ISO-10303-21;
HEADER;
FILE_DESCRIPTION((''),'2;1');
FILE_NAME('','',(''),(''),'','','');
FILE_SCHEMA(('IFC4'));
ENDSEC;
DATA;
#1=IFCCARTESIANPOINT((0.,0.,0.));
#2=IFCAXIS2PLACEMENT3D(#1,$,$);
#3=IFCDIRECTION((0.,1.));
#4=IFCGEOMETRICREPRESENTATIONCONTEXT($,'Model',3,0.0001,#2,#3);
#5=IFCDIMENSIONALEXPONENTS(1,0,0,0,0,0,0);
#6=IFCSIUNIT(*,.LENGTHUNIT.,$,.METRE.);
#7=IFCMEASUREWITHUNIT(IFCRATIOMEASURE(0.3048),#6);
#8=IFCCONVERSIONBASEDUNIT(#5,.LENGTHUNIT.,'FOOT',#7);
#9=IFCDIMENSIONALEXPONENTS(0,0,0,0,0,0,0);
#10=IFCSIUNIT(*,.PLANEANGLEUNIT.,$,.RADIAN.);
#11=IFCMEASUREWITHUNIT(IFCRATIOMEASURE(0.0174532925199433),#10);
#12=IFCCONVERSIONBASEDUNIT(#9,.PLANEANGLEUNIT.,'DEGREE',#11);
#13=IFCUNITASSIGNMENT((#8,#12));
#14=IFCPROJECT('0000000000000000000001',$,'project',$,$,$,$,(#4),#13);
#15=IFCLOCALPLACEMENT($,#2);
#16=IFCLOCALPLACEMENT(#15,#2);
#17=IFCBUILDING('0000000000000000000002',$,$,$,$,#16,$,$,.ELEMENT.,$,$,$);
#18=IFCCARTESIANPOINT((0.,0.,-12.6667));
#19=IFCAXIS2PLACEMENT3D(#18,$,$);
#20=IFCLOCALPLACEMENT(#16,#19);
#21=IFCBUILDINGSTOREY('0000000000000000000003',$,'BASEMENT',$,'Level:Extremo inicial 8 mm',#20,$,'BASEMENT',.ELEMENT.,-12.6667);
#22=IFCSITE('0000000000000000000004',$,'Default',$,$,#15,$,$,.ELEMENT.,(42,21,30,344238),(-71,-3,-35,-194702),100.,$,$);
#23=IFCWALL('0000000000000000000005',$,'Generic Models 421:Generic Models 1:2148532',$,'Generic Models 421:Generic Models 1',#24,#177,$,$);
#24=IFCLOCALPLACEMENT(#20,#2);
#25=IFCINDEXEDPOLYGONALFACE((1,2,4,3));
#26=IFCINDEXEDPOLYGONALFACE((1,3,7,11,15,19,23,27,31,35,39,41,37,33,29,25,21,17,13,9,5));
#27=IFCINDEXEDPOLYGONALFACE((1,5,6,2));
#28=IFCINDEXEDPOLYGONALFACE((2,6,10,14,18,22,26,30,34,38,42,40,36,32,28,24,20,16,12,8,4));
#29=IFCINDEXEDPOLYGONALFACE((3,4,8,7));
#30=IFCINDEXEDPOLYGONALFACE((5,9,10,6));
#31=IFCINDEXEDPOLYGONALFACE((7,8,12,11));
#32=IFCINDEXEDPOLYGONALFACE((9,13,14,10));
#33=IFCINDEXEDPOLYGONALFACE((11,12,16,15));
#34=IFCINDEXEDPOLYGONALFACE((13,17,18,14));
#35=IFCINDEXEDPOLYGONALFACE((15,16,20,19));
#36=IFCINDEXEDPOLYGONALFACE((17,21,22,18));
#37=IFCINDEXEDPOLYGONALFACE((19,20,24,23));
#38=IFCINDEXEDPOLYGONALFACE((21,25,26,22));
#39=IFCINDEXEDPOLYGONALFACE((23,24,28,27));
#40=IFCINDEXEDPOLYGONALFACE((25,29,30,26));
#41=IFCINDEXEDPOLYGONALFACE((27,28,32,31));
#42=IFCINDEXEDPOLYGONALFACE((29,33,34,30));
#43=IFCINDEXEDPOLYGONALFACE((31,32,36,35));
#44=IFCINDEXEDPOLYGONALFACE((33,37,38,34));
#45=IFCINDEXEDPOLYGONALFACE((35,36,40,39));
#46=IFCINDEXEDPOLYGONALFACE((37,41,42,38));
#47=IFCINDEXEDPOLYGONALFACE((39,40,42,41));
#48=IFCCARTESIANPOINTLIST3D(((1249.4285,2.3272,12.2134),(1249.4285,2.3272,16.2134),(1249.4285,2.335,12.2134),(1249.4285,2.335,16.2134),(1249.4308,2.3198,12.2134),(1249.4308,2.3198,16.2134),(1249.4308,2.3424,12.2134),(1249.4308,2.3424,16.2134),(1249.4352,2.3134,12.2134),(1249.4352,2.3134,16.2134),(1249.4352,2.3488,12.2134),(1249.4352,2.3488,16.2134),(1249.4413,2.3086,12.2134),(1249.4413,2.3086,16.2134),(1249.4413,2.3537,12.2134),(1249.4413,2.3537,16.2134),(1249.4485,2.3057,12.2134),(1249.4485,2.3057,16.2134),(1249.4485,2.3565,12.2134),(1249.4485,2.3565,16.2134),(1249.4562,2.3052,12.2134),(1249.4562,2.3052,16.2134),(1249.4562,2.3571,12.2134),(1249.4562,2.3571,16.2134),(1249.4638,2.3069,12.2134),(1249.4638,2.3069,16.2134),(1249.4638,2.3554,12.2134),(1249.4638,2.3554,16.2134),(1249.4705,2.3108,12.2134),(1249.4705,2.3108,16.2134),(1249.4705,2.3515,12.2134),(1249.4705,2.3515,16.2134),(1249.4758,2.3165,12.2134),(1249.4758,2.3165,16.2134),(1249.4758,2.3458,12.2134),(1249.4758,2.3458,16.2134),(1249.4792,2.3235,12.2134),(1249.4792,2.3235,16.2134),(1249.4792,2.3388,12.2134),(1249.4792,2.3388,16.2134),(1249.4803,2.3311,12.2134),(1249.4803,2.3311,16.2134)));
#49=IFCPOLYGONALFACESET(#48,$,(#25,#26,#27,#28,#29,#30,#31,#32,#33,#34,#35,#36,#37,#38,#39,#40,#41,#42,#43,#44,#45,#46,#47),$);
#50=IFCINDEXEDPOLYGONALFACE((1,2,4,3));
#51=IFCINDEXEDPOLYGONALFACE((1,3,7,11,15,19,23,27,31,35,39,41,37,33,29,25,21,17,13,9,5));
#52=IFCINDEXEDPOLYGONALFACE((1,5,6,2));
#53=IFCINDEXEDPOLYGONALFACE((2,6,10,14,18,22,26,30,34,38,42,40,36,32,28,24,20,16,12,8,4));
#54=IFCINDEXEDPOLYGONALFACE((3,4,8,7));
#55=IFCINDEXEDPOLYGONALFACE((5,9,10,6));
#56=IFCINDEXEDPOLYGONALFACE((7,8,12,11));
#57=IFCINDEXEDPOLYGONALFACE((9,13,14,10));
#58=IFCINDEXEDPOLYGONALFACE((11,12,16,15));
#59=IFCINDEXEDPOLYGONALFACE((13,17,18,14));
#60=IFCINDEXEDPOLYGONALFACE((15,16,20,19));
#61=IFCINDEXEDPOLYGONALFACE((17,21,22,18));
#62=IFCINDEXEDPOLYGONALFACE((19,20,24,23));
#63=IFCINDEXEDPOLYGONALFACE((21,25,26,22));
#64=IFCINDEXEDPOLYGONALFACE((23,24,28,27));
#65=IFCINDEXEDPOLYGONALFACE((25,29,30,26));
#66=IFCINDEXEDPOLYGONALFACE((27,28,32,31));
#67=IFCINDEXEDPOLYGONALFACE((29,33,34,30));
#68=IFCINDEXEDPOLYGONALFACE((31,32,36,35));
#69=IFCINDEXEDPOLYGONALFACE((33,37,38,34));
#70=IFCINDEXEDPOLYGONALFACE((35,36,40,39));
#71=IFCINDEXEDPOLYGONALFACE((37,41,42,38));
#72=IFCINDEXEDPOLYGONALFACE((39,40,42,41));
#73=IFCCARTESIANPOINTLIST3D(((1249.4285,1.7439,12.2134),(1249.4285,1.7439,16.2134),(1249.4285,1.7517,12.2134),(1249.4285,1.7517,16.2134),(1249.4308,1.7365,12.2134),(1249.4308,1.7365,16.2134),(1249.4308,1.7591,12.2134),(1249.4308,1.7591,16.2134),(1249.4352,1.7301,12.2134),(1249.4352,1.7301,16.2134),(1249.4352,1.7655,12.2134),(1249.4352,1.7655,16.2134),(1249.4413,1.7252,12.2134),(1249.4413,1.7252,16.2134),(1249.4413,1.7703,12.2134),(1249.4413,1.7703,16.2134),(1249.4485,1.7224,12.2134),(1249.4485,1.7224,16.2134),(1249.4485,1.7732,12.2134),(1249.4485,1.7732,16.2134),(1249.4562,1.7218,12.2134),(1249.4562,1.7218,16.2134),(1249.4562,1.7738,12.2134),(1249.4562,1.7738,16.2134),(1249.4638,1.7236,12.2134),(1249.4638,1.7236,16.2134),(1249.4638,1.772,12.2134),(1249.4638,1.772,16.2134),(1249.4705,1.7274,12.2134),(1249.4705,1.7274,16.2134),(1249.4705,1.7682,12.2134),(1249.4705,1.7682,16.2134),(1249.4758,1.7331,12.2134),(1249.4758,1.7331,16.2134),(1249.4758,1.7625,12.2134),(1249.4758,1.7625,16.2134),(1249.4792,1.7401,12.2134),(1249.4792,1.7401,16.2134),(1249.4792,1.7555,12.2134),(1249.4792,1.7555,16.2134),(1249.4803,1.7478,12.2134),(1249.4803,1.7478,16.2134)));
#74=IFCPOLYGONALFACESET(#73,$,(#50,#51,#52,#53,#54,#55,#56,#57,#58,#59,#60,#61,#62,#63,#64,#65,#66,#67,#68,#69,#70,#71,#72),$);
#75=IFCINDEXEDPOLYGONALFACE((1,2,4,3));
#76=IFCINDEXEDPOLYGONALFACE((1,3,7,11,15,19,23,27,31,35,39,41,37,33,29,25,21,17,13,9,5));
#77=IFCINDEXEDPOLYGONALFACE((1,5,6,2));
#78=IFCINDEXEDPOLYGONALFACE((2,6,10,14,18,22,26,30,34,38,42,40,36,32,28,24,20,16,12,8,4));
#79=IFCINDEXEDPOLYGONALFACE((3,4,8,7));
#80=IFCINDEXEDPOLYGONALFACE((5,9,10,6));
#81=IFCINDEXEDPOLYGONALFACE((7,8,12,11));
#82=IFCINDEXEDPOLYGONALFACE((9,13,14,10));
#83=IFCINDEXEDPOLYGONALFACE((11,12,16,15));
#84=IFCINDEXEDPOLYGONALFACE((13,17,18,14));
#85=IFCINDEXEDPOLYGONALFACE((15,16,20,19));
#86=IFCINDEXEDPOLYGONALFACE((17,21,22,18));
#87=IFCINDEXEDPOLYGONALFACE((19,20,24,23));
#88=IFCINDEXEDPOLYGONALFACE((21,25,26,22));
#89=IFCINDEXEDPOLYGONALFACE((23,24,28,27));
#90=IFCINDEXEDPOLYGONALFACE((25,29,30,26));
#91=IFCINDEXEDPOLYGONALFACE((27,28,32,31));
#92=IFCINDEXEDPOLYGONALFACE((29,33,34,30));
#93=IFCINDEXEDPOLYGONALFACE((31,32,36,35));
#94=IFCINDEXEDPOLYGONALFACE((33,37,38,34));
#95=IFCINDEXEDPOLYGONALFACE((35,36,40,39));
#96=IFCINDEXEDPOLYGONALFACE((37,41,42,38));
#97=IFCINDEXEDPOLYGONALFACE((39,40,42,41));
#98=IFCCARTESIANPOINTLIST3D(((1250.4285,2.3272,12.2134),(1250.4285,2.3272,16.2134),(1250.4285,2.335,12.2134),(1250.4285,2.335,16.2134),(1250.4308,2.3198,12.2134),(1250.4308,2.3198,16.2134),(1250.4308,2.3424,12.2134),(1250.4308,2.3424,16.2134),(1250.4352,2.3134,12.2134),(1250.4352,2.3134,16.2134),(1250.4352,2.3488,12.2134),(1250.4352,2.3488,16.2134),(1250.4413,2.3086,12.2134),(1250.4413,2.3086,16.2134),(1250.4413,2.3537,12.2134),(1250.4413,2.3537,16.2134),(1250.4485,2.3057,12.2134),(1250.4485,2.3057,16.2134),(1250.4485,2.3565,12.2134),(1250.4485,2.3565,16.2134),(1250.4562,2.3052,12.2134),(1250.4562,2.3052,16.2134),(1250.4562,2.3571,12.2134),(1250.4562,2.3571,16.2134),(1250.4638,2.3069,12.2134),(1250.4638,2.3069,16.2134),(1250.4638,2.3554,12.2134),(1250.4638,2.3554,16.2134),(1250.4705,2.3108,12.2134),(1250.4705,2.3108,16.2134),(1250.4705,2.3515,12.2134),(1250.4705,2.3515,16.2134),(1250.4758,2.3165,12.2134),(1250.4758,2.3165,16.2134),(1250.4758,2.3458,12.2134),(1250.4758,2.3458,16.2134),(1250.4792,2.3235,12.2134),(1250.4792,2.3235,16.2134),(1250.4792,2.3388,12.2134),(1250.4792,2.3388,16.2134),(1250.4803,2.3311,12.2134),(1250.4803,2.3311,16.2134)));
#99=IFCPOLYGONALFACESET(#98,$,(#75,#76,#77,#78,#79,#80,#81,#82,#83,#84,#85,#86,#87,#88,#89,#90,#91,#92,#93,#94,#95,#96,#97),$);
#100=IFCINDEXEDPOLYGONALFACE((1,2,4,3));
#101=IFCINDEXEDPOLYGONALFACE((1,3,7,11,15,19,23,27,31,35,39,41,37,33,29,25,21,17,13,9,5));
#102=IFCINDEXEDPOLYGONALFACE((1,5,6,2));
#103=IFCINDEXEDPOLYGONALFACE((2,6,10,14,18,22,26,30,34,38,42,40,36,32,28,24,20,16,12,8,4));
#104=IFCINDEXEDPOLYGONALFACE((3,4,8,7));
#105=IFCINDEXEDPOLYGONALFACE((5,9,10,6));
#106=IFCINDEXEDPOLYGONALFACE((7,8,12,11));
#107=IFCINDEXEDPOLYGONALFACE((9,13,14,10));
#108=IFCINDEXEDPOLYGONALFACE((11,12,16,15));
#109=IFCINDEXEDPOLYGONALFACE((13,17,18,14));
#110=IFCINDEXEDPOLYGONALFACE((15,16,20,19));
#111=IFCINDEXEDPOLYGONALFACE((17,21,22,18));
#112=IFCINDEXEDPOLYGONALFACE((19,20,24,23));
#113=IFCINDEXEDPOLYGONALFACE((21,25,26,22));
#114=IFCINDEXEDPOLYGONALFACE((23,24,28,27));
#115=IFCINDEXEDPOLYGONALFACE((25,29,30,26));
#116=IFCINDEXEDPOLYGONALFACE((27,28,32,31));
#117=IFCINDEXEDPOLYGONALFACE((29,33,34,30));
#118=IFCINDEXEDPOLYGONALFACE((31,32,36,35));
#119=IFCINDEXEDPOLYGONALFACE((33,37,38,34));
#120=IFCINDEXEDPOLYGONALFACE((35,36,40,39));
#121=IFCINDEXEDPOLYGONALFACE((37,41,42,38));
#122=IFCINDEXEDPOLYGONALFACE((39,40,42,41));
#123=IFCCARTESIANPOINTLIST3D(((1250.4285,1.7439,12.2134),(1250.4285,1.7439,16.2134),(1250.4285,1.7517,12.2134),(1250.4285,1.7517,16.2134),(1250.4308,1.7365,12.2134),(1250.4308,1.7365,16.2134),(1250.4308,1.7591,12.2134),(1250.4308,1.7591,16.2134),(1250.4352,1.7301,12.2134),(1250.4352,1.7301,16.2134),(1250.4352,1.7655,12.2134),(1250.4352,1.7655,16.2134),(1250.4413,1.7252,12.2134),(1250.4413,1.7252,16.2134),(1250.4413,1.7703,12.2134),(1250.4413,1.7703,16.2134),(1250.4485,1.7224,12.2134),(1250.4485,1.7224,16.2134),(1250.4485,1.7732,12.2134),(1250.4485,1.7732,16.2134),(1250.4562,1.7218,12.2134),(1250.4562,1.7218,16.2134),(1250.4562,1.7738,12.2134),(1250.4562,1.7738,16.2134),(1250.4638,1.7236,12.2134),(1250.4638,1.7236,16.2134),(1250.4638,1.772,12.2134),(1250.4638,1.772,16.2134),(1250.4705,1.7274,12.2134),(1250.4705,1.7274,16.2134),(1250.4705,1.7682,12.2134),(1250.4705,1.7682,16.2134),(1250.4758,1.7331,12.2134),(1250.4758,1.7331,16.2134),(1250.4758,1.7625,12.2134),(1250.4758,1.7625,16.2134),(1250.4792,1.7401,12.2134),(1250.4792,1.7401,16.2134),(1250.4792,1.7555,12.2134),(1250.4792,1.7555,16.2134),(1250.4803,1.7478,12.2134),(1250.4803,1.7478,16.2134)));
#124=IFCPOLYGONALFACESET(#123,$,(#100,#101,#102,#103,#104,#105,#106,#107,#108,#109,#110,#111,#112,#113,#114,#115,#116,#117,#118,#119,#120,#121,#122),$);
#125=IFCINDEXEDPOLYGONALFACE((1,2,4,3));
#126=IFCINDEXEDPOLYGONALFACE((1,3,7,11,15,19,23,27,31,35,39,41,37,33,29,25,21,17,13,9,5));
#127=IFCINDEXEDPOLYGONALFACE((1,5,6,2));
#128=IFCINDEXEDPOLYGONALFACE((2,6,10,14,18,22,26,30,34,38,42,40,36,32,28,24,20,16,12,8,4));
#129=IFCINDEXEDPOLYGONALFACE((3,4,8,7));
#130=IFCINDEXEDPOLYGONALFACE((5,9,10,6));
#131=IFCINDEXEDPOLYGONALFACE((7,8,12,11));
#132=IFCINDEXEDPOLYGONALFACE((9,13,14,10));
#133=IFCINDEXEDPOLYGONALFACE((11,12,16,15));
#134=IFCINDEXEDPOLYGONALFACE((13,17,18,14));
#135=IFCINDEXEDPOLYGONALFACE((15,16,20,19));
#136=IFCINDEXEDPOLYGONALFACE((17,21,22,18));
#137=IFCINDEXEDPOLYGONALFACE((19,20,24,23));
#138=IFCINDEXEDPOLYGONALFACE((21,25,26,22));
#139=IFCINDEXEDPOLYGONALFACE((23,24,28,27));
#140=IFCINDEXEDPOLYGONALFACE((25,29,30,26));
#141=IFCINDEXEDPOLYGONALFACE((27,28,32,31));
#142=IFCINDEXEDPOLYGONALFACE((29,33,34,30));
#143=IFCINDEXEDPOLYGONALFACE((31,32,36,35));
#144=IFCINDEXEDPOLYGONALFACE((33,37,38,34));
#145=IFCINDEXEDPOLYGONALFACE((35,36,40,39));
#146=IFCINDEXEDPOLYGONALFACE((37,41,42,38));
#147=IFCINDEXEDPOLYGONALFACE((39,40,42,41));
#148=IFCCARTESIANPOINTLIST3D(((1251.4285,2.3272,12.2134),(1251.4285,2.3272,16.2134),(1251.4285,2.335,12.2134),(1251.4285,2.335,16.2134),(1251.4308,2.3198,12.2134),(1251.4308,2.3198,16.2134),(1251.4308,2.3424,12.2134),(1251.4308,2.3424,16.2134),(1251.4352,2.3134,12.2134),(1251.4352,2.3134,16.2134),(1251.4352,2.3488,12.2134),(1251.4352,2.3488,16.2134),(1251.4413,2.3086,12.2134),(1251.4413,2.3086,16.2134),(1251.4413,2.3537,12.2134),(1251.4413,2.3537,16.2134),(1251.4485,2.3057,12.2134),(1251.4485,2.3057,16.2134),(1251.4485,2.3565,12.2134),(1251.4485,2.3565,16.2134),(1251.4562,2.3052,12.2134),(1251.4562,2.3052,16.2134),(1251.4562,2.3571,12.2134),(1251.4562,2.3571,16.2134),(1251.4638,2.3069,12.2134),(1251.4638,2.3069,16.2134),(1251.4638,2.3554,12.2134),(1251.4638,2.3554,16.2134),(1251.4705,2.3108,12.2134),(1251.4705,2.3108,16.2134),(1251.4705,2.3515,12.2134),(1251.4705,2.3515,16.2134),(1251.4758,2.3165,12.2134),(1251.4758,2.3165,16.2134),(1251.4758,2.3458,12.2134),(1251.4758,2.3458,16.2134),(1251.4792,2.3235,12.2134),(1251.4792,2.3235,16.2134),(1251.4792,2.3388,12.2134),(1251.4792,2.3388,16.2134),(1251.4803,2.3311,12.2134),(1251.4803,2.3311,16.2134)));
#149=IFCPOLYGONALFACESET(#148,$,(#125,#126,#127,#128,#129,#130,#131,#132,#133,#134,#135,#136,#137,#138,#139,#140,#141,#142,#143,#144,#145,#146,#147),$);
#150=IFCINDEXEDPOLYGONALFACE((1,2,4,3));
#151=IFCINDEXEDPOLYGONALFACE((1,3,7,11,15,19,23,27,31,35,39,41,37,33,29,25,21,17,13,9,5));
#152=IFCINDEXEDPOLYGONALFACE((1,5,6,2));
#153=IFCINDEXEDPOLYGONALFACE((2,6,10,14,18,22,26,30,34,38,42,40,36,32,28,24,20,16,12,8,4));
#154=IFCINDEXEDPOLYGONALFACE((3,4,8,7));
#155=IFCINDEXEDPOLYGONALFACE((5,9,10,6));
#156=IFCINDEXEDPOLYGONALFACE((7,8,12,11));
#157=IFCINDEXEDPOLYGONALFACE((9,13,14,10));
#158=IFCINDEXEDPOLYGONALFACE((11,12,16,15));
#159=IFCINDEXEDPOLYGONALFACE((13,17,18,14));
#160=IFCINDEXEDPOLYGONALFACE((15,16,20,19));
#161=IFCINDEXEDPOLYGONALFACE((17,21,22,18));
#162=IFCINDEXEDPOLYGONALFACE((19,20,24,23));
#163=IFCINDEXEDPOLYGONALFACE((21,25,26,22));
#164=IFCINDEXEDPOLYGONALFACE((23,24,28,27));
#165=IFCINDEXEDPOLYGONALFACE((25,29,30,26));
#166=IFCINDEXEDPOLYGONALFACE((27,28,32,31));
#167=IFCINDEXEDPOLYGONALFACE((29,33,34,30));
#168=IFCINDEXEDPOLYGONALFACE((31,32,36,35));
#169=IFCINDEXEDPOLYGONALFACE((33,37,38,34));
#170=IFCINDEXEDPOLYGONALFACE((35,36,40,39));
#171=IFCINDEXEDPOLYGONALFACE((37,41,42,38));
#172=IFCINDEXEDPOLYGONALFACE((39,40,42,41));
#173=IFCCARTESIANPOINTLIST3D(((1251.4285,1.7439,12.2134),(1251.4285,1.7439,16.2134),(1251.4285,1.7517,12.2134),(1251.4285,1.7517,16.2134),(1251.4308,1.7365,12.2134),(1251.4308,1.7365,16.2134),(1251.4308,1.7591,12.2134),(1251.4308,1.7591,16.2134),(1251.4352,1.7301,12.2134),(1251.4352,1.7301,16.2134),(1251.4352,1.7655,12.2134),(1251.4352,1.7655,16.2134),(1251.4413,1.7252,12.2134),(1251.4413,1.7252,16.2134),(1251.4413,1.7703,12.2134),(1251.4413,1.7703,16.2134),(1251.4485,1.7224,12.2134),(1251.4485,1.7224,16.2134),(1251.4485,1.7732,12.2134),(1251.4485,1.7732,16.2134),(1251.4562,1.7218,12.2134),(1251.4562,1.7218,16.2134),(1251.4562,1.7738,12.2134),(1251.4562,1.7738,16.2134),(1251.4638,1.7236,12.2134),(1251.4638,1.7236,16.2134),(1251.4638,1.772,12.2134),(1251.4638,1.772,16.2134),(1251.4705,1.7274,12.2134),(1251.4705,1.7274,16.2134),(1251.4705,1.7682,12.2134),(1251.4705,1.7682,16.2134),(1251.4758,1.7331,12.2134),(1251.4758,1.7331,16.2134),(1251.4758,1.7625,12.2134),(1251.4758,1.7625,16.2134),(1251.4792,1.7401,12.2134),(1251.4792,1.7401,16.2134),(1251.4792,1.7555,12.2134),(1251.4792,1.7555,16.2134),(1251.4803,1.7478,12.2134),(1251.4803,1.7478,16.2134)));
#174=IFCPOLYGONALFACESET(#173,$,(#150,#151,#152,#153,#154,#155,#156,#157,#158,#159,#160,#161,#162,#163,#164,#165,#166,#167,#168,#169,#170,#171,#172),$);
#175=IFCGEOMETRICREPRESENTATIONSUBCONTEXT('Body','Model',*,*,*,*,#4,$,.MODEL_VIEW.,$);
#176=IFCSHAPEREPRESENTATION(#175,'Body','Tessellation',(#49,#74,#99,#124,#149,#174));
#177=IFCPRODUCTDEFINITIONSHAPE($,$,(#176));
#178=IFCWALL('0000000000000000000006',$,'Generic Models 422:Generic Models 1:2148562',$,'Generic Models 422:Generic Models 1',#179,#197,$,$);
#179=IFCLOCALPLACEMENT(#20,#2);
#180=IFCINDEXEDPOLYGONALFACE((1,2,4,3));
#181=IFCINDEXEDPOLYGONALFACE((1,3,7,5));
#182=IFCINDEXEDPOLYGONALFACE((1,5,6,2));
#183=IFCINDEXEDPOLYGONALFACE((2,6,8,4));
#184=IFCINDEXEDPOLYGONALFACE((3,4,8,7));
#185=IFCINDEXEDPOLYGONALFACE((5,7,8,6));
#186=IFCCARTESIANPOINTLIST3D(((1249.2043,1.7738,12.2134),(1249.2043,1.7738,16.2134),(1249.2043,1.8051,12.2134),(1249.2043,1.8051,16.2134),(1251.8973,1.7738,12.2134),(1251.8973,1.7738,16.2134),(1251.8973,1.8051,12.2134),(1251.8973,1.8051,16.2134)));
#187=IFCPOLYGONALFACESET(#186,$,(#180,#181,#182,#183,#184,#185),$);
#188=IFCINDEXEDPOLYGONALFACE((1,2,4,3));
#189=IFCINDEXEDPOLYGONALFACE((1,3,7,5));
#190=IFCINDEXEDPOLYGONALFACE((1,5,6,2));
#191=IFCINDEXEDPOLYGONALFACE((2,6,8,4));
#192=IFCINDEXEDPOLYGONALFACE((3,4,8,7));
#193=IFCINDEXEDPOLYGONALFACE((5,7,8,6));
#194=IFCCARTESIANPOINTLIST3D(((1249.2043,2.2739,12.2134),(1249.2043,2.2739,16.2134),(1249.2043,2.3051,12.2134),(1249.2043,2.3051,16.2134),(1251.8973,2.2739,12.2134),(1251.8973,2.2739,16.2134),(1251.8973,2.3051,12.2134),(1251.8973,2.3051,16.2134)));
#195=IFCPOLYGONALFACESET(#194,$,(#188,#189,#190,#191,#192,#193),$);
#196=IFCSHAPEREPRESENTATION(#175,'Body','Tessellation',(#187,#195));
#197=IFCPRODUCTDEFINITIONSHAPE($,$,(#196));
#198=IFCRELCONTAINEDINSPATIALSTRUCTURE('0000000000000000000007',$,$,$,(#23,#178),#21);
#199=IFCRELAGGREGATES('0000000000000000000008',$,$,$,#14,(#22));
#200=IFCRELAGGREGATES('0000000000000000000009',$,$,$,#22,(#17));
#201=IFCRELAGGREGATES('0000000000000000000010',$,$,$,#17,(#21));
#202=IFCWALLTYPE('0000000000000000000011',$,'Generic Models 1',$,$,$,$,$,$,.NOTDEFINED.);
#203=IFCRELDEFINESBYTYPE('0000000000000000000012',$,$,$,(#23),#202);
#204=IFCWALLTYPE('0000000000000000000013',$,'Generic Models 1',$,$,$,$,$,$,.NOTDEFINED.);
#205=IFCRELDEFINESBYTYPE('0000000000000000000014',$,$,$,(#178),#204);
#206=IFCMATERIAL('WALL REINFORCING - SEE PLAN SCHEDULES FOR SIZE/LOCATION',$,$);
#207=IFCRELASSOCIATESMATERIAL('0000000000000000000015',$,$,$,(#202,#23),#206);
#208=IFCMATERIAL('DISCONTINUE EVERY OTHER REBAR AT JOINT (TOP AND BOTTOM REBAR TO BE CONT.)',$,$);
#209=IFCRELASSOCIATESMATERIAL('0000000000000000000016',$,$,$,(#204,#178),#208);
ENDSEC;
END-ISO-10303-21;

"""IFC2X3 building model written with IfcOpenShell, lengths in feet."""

from ifc_helpers import new_model, entity, si_unit, converted_unit, direction, frame, origin, origin_2d_with_axis, place, context, subcontext, project, spatial, rectangle, circle, extrude, material, type_object, element, save


model = new_model("IFC2X3")

# Units and contexts
model_context = context("Model", 3, precision=0.0001, world=origin(), true_north=direction((0.0, 1.0)))
body_context = subcontext(model_context, "Body", "Model", "MODEL_VIEW")
ifc_project = project(units=[converted_unit("LENGTHUNIT", "FOOT", entity("IfcRatioMeasure", 0.3048), si_unit("LENGTHUNIT", "METRE"), dimensions=[1, 0, 0, 0, 0, 0, 0]), converted_unit("PLANEANGLEUNIT", "DEGREE", entity("IfcRatioMeasure", 0.0174532925199433), si_unit("PLANEANGLEUNIT", "RADIAN"), dimensions=[0, 0, 0, 0, 0, 0, 0])], contexts=[model_context])

# Site, building, storey
site_placement = place(None, origin())
site = spatial("IfcSite", under=ifc_project, at=site_placement, Name="Default", CompositionType="ELEMENT", RefLatitude=(42, 21, 30, 344238), RefLongitude=(-71, -3, -35, -194702), RefElevation=100.0)
building_placement = place(site_placement, origin())
building = spatial("IfcBuilding", under=site, at=building_placement, CompositionType="ELEMENT")
storey_placement = place(building_placement, frame((0.0, 0.0, -12.6667)))
storey = spatial("IfcBuildingStorey", under=building, at=storey_placement, Name="BASEMENT", ObjectType="Level:Extremo inicial 8 mm", LongName="BASEMENT", CompositionType="ELEMENT", Elevation=-12.6667)

# Walls
ifc_material_1 = material(Name="WALL REINFORCING - SEE PLAN SCHEDULES FOR SIZE/LOCATION")
wall_type_1 = type_object("IfcWallType", Name="Generic Models 1", PredefinedType="NOTDEFINED", material=ifc_material_1)
wall_1_placement = place(storey_placement, frame((1249.4282, 1.7218, 12.2134)))
element("IfcWall", 1, at=wall_1_placement, inside=storey, type_object=wall_type_1, material=ifc_material_1, Name="Generic Models 421:Generic Models 1:2148532", ObjectType="Generic Models 421:Generic Models 1", context=body_context, shape_type="SweptSolid", body=[
    extrude(circle(Radius=0.026, at=origin_2d_with_axis()), frame((0.026, 0.6094, 0.0)), (0.0, 0.0, 1.0), 4.0),
    extrude(circle(Radius=0.026, at=origin_2d_with_axis()), frame((0.026, 0.026, 0.0)), (0.0, 0.0, 1.0), 4.0),
    extrude(circle(Radius=0.026, at=origin_2d_with_axis()), frame((1.026, 0.6094, 0.0)), (0.0, 0.0, 1.0), 4.0),
    extrude(circle(Radius=0.026, at=origin_2d_with_axis()), frame((1.026, 0.026, 0.0)), (0.0, 0.0, 1.0), 4.0),
    extrude(circle(Radius=0.026, at=origin_2d_with_axis()), frame((2.026, 0.6094, 0.0)), (0.0, 0.0, 1.0), 4.0),
    extrude(circle(Radius=0.026, at=origin_2d_with_axis()), frame((2.026, 0.026, 0.0)), (0.0, 0.0, 1.0), 4.0),
])
ifc_material_2 = material(Name="DISCONTINUE EVERY OTHER REBAR AT JOINT (TOP AND BOTTOM REBAR TO BE CONT.)")
wall_type_2 = type_object("IfcWallType", Name="Generic Models 1", PredefinedType="NOTDEFINED", material=ifc_material_2)
wall_2_placement = place(storey_placement, frame((1249.2043, 1.7738, 12.2134)))
element("IfcWall", 2, at=wall_2_placement, inside=storey, type_object=wall_type_2, material=ifc_material_2, Name="Generic Models 422:Generic Models 1:2148562", ObjectType="Generic Models 422:Generic Models 1", context=body_context, shape_type="SweptSolid", body=[
    extrude(rectangle(XDim=0.0312, YDim=2.693, at=origin_2d_with_axis()), frame((1.3465, 0.0156, 0.0), z_axis=(0.0, 0.0, 1.0), x_axis=(0.0, 1.0, 0.0)), (0.0, 0.0, 1.0), 4.0),
    extrude(rectangle(XDim=0.0312, YDim=2.693, at=origin_2d_with_axis()), frame((1.3465, 0.5157, 0.0), z_axis=(0.0, 0.0, 1.0), x_axis=(0.0, 1.0, 0.0)), (0.0, 0.0, 1.0), 4.0),
])

save(model, "model.ifc")
